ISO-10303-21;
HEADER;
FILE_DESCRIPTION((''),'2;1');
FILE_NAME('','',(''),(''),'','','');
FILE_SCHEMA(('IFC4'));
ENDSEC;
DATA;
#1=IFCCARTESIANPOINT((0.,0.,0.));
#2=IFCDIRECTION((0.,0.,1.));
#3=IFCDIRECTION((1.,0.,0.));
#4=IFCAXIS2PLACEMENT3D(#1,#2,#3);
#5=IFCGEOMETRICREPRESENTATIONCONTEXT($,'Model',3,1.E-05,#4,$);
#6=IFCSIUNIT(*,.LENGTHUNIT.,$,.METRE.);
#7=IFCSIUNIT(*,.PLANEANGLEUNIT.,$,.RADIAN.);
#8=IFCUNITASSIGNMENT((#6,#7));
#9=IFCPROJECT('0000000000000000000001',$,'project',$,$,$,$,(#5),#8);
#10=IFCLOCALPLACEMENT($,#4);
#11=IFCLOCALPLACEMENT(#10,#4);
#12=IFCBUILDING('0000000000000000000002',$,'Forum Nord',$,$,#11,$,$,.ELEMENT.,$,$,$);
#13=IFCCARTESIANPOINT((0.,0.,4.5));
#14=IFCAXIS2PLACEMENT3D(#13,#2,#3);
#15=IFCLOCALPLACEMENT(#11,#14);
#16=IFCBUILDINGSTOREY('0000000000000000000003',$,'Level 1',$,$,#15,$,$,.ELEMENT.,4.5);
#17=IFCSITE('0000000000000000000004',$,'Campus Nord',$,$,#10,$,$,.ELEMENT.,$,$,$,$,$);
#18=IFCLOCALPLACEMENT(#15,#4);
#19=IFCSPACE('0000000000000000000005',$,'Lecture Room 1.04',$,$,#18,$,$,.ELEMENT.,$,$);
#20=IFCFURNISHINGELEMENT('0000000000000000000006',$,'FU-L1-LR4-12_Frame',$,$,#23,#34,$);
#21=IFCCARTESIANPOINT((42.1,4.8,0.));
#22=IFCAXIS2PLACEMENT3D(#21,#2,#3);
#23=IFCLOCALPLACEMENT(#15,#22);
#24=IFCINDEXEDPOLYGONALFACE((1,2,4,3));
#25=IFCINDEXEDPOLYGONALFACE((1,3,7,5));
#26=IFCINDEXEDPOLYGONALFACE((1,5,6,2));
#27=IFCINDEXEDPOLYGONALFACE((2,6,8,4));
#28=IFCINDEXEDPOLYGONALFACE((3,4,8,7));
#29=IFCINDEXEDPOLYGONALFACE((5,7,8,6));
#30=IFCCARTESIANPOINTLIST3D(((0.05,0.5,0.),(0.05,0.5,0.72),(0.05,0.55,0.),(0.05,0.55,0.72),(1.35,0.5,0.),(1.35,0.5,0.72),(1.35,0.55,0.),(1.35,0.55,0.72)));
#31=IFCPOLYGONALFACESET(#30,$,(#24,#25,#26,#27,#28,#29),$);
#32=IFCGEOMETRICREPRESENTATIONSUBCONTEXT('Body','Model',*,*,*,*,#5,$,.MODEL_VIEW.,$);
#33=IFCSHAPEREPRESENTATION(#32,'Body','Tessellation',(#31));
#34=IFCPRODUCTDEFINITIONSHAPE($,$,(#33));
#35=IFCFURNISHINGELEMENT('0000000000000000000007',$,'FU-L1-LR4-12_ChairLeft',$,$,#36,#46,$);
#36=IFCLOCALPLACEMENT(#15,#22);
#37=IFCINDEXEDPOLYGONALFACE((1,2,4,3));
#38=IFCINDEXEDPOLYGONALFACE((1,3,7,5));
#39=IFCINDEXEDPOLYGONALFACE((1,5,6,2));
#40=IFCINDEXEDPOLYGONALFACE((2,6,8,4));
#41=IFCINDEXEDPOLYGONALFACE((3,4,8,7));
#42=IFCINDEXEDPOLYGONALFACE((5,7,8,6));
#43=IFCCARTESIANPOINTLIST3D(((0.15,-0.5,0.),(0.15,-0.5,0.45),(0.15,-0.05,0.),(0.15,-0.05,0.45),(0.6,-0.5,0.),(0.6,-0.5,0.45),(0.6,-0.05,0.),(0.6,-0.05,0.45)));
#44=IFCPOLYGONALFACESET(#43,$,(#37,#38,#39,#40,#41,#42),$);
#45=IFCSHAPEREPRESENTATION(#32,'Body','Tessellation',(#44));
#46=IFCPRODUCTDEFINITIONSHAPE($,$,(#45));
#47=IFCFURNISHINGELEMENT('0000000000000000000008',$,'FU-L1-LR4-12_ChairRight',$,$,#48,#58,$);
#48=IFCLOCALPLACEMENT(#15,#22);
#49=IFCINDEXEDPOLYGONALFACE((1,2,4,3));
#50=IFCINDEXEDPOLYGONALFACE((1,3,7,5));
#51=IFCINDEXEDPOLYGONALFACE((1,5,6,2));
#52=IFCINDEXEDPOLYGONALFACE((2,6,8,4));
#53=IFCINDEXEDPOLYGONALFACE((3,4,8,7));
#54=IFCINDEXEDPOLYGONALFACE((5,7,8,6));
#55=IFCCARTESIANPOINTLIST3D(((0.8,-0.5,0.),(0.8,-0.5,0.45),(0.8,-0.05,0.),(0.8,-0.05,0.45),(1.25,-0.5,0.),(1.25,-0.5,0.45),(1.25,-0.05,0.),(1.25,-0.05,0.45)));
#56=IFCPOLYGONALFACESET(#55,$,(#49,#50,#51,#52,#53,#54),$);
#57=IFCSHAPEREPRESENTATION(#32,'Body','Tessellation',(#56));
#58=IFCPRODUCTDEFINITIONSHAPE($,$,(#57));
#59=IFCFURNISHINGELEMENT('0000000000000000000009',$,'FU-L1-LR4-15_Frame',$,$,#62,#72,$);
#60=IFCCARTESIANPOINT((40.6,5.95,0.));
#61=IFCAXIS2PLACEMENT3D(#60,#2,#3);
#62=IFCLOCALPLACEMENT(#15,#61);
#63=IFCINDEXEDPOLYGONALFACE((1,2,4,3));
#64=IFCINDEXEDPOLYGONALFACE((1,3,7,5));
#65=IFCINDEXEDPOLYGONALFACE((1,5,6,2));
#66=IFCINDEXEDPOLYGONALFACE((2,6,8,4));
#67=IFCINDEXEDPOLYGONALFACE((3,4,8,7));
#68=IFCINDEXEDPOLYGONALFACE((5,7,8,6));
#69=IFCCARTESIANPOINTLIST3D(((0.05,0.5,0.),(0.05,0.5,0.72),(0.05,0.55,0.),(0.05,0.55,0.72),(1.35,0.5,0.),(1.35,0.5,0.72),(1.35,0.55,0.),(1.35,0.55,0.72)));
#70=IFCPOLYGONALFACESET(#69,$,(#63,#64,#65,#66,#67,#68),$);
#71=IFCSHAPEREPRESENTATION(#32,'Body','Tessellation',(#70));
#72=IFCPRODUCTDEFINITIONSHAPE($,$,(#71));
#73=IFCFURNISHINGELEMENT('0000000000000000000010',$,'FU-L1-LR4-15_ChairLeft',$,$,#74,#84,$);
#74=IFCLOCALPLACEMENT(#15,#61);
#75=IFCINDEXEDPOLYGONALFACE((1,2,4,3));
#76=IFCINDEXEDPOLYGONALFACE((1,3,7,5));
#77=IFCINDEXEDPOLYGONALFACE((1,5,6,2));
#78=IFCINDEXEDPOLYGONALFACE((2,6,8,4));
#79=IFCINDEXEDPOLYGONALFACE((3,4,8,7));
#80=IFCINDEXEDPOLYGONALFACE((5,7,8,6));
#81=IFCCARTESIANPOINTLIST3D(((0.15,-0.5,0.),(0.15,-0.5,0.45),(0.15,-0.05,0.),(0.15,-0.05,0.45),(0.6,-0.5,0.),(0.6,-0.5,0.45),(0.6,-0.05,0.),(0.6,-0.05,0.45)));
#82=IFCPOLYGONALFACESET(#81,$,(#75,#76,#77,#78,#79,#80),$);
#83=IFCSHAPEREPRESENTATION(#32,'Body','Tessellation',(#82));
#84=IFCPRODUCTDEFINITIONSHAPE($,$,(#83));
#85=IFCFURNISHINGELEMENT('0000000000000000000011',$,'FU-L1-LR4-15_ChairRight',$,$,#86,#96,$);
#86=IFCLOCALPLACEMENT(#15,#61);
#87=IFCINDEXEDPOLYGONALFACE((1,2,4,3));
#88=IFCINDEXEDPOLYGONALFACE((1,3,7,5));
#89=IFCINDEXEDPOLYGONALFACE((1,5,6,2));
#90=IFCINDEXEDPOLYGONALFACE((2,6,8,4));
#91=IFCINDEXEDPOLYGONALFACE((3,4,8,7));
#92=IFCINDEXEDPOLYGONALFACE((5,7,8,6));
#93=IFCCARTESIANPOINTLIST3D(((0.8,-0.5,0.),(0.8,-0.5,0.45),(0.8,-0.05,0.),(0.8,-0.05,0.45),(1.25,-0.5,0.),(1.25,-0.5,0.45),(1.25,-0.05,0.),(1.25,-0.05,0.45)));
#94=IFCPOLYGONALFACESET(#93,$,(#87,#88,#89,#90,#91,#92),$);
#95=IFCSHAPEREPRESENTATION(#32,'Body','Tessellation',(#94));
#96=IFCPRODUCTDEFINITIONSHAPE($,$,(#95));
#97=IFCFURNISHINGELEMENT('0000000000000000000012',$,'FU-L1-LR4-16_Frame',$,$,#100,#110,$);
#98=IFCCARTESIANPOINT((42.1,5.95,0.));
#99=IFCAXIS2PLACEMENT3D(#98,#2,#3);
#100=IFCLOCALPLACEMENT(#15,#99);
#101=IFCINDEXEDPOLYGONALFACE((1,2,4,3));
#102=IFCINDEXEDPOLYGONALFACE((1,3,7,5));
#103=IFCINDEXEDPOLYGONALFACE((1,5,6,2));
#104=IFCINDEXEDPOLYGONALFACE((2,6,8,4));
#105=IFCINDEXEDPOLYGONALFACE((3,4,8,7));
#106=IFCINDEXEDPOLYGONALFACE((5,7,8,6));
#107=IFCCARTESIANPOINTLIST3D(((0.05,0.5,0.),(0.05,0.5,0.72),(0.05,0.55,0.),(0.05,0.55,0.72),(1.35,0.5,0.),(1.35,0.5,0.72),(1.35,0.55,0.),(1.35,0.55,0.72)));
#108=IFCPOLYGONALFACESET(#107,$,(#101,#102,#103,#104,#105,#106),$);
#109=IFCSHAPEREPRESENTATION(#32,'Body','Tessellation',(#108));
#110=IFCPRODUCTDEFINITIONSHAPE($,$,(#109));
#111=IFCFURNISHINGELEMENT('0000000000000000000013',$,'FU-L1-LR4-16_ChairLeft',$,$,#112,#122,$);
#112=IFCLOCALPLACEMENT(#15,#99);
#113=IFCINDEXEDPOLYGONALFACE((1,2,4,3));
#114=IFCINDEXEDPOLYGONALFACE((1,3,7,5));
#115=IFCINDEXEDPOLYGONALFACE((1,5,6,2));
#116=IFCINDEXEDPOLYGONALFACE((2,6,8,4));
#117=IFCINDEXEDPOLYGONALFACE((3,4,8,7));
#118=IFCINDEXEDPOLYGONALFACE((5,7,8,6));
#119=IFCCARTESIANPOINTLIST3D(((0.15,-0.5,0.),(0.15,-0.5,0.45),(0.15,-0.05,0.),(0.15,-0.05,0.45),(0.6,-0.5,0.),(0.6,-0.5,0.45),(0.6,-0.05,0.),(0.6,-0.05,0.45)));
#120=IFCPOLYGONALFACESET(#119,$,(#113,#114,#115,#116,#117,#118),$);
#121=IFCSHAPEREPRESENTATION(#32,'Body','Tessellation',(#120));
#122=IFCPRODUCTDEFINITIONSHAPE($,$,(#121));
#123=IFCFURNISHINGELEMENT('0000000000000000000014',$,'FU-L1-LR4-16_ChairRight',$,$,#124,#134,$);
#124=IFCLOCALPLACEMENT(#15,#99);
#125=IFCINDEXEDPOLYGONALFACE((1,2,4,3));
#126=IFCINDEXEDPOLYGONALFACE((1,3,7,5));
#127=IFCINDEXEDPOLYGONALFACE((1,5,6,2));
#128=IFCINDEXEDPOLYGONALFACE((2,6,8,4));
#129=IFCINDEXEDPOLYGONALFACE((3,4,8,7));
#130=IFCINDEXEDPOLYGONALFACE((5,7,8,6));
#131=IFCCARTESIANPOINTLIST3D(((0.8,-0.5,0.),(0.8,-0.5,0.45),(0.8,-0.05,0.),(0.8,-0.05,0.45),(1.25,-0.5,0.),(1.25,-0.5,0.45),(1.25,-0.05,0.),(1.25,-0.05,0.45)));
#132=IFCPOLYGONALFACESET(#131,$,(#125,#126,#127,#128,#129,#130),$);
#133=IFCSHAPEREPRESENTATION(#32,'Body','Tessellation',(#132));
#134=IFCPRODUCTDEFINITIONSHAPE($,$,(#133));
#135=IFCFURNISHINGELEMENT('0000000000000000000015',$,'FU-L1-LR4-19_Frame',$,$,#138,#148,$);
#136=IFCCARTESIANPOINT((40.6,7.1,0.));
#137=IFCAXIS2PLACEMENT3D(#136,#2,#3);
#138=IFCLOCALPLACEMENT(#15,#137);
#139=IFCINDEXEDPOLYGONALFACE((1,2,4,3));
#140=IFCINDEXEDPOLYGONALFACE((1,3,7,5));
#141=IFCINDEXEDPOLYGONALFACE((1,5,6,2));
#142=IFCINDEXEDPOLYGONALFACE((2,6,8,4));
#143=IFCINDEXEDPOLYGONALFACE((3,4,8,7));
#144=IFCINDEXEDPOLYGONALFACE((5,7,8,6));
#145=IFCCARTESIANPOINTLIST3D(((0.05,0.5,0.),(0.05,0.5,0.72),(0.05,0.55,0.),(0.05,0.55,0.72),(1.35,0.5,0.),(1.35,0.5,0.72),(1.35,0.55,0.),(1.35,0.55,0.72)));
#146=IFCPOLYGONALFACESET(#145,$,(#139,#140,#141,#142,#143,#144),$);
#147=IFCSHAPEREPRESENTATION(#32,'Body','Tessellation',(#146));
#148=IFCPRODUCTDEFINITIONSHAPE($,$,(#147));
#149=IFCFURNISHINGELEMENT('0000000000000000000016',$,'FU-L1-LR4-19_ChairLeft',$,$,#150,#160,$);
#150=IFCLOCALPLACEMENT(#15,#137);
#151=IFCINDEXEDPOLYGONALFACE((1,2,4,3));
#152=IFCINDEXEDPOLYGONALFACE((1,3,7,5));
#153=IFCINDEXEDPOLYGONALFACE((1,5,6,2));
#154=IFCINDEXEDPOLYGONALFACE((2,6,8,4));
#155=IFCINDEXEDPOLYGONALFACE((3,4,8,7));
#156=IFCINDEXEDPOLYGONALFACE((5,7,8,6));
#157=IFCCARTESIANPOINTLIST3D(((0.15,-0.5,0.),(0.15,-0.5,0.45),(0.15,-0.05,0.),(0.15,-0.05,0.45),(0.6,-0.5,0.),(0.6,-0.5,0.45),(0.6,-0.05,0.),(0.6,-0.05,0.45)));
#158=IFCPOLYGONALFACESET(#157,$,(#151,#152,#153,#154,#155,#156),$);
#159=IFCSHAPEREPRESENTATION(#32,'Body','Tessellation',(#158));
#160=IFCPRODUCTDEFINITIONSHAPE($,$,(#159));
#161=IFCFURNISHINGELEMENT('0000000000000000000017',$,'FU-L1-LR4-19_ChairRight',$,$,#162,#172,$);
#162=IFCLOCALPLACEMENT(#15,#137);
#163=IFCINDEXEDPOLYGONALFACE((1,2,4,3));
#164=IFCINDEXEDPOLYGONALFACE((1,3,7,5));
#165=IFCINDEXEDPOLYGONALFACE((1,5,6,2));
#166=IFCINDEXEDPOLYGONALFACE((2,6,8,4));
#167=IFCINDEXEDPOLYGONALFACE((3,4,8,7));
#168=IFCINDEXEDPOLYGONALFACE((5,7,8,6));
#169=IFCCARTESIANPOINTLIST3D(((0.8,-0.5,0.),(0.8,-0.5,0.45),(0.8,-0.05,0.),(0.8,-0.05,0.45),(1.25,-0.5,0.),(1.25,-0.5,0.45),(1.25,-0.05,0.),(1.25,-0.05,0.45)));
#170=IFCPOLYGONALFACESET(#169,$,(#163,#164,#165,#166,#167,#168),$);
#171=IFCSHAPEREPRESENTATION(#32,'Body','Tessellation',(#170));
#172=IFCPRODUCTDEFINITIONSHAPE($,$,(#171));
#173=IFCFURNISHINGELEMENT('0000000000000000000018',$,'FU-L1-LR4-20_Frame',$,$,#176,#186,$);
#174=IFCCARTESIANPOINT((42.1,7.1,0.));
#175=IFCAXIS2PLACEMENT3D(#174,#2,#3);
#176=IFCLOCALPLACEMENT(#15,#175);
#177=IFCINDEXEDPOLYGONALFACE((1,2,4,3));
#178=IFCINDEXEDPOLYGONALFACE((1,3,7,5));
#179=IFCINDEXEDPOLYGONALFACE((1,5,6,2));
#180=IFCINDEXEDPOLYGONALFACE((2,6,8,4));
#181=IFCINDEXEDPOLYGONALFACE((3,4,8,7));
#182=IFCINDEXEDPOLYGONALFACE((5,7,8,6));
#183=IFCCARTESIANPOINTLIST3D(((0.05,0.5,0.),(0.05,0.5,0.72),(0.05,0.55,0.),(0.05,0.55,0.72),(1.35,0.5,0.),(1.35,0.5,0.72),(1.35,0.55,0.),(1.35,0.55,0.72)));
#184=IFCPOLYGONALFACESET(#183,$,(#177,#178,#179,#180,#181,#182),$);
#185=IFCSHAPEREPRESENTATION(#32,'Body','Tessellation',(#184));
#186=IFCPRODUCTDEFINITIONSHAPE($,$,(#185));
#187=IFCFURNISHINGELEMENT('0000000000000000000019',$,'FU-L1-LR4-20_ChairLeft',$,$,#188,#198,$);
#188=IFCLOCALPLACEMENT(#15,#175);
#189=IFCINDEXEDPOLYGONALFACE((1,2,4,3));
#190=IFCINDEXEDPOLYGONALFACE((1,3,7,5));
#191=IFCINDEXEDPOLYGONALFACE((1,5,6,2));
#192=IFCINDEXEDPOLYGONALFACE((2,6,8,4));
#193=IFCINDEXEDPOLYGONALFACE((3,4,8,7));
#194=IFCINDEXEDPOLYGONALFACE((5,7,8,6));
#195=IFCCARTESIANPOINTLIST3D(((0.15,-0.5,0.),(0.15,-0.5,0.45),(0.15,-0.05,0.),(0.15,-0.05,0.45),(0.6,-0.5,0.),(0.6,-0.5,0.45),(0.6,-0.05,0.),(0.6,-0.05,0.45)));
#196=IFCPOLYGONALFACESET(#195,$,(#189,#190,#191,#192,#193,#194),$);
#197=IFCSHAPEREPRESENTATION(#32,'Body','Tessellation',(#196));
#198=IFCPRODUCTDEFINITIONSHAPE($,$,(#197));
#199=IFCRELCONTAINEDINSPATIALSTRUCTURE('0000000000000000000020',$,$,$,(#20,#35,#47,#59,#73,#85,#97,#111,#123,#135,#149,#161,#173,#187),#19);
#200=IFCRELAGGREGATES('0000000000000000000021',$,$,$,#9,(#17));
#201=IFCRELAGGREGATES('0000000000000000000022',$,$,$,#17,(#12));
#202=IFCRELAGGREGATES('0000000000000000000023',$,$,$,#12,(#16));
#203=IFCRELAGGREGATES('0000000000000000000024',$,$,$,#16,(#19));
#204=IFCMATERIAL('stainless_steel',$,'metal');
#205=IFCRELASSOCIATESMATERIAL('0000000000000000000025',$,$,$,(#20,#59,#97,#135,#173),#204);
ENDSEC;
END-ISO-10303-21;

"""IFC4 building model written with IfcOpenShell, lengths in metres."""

from ifc_helpers import new_model, si_unit, frame, frame_2d, origin_with_axes, place, context, subcontext, project, spatial, rectangle, extrude, material, element, save


model = new_model("IFC4")

# Units and contexts
model_context = context("Model", 3, precision=1e-05, world=origin_with_axes())
body_context = subcontext(model_context, "Body", "Model", "MODEL_VIEW")
ifc_project = project(units=[si_unit("LENGTHUNIT", "METRE"), si_unit("PLANEANGLEUNIT", "RADIAN")], contexts=[model_context])

# Site, building, storey
site_placement = place(None, origin_with_axes())
site = spatial("IfcSite", under=ifc_project, at=site_placement, Name="Campus Nord", CompositionType="ELEMENT")
building_placement = place(site_placement, origin_with_axes())
building = spatial("IfcBuilding", under=site, at=building_placement, Name="Forum Nord", CompositionType="ELEMENT")
storey_placement = place(building_placement, frame((0.0, 0.0, 4.5), z_axis=(0.0, 0.0, 1.0), x_axis=(1.0, 0.0, 0.0)))
storey = spatial("IfcBuildingStorey", under=building, at=storey_placement, Name="Level 1", CompositionType="ELEMENT", Elevation=4.5)

# Shared definitions
space_placement = place(storey_placement, origin_with_axes())
space = spatial("IfcSpace", under=storey, at=space_placement, Name="Lecture Room 1.04", CompositionType="ELEMENT")

# Furnishing elements
ifc_material_1 = material(Name="stainless_steel", Category="metal")
furnishing_1_placement = place(storey_placement, frame((42.1, 4.8, 0.0), z_axis=(0.0, 0.0, 1.0), x_axis=(1.0, 0.0, 0.0)))
element("IfcFurnishingElement", 1, at=furnishing_1_placement, inside=space, material=ifc_material_1, Name="FU-L1-LR4-12_Frame", context=body_context, shape_type="SweptSolid", body=[
    extrude(rectangle(XDim=1.3, YDim=0.05, at=frame_2d((0.7, 0.525), x_axis=(1.0, 0.0))), origin_with_axes(), (0.0, 0.0, 1.0), 0.72),
])
furnishing_2_placement = place(storey_placement, frame((42.1, 4.8, 0.0), z_axis=(0.0, 0.0, 1.0), x_axis=(1.0, 0.0, 0.0)))
element("IfcFurnishingElement", 2, at=furnishing_2_placement, inside=space, Name="FU-L1-LR4-12_ChairLeft", context=body_context, shape_type="SweptSolid", body=[
    extrude(rectangle(XDim=0.45, YDim=0.45, at=frame_2d((0.375, -0.275), x_axis=(1.0, 0.0))), origin_with_axes(), (0.0, 0.0, 1.0), 0.45),
])
furnishing_3_placement = place(storey_placement, frame((42.1, 4.8, 0.0), z_axis=(0.0, 0.0, 1.0), x_axis=(1.0, 0.0, 0.0)))
element("IfcFurnishingElement", 3, at=furnishing_3_placement, inside=space, Name="FU-L1-LR4-12_ChairRight", context=body_context, shape_type="SweptSolid", body=[
    extrude(rectangle(XDim=0.45, YDim=0.45, at=frame_2d((1.025, -0.275), x_axis=(1.0, 0.0))), origin_with_axes(), (0.0, 0.0, 1.0), 0.45),
])
furnishing_4_placement = place(storey_placement, frame((40.6, 5.95, 0.0), z_axis=(0.0, 0.0, 1.0), x_axis=(1.0, 0.0, 0.0)))
element("IfcFurnishingElement", 4, at=furnishing_4_placement, inside=space, material=ifc_material_1, Name="FU-L1-LR4-15_Frame", context=body_context, shape_type="SweptSolid", body=[
    extrude(rectangle(XDim=1.3, YDim=0.05, at=frame_2d((0.7, 0.525), x_axis=(1.0, 0.0))), origin_with_axes(), (0.0, 0.0, 1.0), 0.72),
])
furnishing_5_placement = place(storey_placement, frame((40.6, 5.95, 0.0), z_axis=(0.0, 0.0, 1.0), x_axis=(1.0, 0.0, 0.0)))
element("IfcFurnishingElement", 5, at=furnishing_5_placement, inside=space, Name="FU-L1-LR4-15_ChairLeft", context=body_context, shape_type="SweptSolid", body=[
    extrude(rectangle(XDim=0.45, YDim=0.45, at=frame_2d((0.375, -0.275), x_axis=(1.0, 0.0))), origin_with_axes(), (0.0, 0.0, 1.0), 0.45),
])
furnishing_6_placement = place(storey_placement, frame((40.6, 5.95, 0.0), z_axis=(0.0, 0.0, 1.0), x_axis=(1.0, 0.0, 0.0)))
element("IfcFurnishingElement", 6, at=furnishing_6_placement, inside=space, Name="FU-L1-LR4-15_ChairRight", context=body_context, shape_type="SweptSolid", body=[
    extrude(rectangle(XDim=0.45, YDim=0.45, at=frame_2d((1.025, -0.275), x_axis=(1.0, 0.0))), origin_with_axes(), (0.0, 0.0, 1.0), 0.45),
])
furnishing_7_placement = place(storey_placement, frame((42.1, 5.95, 0.0), z_axis=(0.0, 0.0, 1.0), x_axis=(1.0, 0.0, 0.0)))
element("IfcFurnishingElement", 7, at=furnishing_7_placement, inside=space, material=ifc_material_1, Name="FU-L1-LR4-16_Frame", context=body_context, shape_type="SweptSolid", body=[
    extrude(rectangle(XDim=1.3, YDim=0.05, at=frame_2d((0.7, 0.525), x_axis=(1.0, 0.0))), origin_with_axes(), (0.0, 0.0, 1.0), 0.72),
])
furnishing_8_placement = place(storey_placement, frame((42.1, 5.95, 0.0), z_axis=(0.0, 0.0, 1.0), x_axis=(1.0, 0.0, 0.0)))
element("IfcFurnishingElement", 8, at=furnishing_8_placement, inside=space, Name="FU-L1-LR4-16_ChairLeft", context=body_context, shape_type="SweptSolid", body=[
    extrude(rectangle(XDim=0.45, YDim=0.45, at=frame_2d((0.375, -0.275), x_axis=(1.0, 0.0))), origin_with_axes(), (0.0, 0.0, 1.0), 0.45),
])
furnishing_9_placement = place(storey_placement, frame((42.1, 5.95, 0.0), z_axis=(0.0, 0.0, 1.0), x_axis=(1.0, 0.0, 0.0)))
element("IfcFurnishingElement", 9, at=furnishing_9_placement, inside=space, Name="FU-L1-LR4-16_ChairRight", context=body_context, shape_type="SweptSolid", body=[
    extrude(rectangle(XDim=0.45, YDim=0.45, at=frame_2d((1.025, -0.275), x_axis=(1.0, 0.0))), origin_with_axes(), (0.0, 0.0, 1.0), 0.45),
])
furnishing_10_placement = place(storey_placement, frame((40.6, 7.1, 0.0), z_axis=(0.0, 0.0, 1.0), x_axis=(1.0, 0.0, 0.0)))
element("IfcFurnishingElement", 10, at=furnishing_10_placement, inside=space, material=ifc_material_1, Name="FU-L1-LR4-19_Frame", context=body_context, shape_type="SweptSolid", body=[
    extrude(rectangle(XDim=1.3, YDim=0.05, at=frame_2d((0.7, 0.525), x_axis=(1.0, 0.0))), origin_with_axes(), (0.0, 0.0, 1.0), 0.72),
])
furnishing_11_placement = place(storey_placement, frame((40.6, 7.1, 0.0), z_axis=(0.0, 0.0, 1.0), x_axis=(1.0, 0.0, 0.0)))
element("IfcFurnishingElement", 11, at=furnishing_11_placement, inside=space, Name="FU-L1-LR4-19_ChairLeft", context=body_context, shape_type="SweptSolid", body=[
    extrude(rectangle(XDim=0.45, YDim=0.45, at=frame_2d((0.375, -0.275), x_axis=(1.0, 0.0))), origin_with_axes(), (0.0, 0.0, 1.0), 0.45),
])
furnishing_12_placement = place(storey_placement, frame((40.6, 7.1, 0.0), z_axis=(0.0, 0.0, 1.0), x_axis=(1.0, 0.0, 0.0)))
element("IfcFurnishingElement", 12, at=furnishing_12_placement, inside=space, Name="FU-L1-LR4-19_ChairRight", context=body_context, shape_type="SweptSolid", body=[
    extrude(rectangle(XDim=0.45, YDim=0.45, at=frame_2d((1.025, -0.275), x_axis=(1.0, 0.0))), origin_with_axes(), (0.0, 0.0, 1.0), 0.45),
])
furnishing_13_placement = place(storey_placement, frame((42.1, 7.1, 0.0), z_axis=(0.0, 0.0, 1.0), x_axis=(1.0, 0.0, 0.0)))
element("IfcFurnishingElement", 13, at=furnishing_13_placement, inside=space, material=ifc_material_1, Name="FU-L1-LR4-20_Frame", context=body_context, shape_type="SweptSolid", body=[
    extrude(rectangle(XDim=1.3, YDim=0.05, at=frame_2d((0.7, 0.525), x_axis=(1.0, 0.0))), origin_with_axes(), (0.0, 0.0, 1.0), 0.72),
])
furnishing_14_placement = place(storey_placement, frame((42.1, 7.1, 0.0), z_axis=(0.0, 0.0, 1.0), x_axis=(1.0, 0.0, 0.0)))
element("IfcFurnishingElement", 14, at=furnishing_14_placement, inside=space, Name="FU-L1-LR4-20_ChairLeft", context=body_context, shape_type="SweptSolid", body=[
    extrude(rectangle(XDim=0.45, YDim=0.45, at=frame_2d((0.375, -0.275), x_axis=(1.0, 0.0))), origin_with_axes(), (0.0, 0.0, 1.0), 0.45),
])

save(model, "model.ifc")
